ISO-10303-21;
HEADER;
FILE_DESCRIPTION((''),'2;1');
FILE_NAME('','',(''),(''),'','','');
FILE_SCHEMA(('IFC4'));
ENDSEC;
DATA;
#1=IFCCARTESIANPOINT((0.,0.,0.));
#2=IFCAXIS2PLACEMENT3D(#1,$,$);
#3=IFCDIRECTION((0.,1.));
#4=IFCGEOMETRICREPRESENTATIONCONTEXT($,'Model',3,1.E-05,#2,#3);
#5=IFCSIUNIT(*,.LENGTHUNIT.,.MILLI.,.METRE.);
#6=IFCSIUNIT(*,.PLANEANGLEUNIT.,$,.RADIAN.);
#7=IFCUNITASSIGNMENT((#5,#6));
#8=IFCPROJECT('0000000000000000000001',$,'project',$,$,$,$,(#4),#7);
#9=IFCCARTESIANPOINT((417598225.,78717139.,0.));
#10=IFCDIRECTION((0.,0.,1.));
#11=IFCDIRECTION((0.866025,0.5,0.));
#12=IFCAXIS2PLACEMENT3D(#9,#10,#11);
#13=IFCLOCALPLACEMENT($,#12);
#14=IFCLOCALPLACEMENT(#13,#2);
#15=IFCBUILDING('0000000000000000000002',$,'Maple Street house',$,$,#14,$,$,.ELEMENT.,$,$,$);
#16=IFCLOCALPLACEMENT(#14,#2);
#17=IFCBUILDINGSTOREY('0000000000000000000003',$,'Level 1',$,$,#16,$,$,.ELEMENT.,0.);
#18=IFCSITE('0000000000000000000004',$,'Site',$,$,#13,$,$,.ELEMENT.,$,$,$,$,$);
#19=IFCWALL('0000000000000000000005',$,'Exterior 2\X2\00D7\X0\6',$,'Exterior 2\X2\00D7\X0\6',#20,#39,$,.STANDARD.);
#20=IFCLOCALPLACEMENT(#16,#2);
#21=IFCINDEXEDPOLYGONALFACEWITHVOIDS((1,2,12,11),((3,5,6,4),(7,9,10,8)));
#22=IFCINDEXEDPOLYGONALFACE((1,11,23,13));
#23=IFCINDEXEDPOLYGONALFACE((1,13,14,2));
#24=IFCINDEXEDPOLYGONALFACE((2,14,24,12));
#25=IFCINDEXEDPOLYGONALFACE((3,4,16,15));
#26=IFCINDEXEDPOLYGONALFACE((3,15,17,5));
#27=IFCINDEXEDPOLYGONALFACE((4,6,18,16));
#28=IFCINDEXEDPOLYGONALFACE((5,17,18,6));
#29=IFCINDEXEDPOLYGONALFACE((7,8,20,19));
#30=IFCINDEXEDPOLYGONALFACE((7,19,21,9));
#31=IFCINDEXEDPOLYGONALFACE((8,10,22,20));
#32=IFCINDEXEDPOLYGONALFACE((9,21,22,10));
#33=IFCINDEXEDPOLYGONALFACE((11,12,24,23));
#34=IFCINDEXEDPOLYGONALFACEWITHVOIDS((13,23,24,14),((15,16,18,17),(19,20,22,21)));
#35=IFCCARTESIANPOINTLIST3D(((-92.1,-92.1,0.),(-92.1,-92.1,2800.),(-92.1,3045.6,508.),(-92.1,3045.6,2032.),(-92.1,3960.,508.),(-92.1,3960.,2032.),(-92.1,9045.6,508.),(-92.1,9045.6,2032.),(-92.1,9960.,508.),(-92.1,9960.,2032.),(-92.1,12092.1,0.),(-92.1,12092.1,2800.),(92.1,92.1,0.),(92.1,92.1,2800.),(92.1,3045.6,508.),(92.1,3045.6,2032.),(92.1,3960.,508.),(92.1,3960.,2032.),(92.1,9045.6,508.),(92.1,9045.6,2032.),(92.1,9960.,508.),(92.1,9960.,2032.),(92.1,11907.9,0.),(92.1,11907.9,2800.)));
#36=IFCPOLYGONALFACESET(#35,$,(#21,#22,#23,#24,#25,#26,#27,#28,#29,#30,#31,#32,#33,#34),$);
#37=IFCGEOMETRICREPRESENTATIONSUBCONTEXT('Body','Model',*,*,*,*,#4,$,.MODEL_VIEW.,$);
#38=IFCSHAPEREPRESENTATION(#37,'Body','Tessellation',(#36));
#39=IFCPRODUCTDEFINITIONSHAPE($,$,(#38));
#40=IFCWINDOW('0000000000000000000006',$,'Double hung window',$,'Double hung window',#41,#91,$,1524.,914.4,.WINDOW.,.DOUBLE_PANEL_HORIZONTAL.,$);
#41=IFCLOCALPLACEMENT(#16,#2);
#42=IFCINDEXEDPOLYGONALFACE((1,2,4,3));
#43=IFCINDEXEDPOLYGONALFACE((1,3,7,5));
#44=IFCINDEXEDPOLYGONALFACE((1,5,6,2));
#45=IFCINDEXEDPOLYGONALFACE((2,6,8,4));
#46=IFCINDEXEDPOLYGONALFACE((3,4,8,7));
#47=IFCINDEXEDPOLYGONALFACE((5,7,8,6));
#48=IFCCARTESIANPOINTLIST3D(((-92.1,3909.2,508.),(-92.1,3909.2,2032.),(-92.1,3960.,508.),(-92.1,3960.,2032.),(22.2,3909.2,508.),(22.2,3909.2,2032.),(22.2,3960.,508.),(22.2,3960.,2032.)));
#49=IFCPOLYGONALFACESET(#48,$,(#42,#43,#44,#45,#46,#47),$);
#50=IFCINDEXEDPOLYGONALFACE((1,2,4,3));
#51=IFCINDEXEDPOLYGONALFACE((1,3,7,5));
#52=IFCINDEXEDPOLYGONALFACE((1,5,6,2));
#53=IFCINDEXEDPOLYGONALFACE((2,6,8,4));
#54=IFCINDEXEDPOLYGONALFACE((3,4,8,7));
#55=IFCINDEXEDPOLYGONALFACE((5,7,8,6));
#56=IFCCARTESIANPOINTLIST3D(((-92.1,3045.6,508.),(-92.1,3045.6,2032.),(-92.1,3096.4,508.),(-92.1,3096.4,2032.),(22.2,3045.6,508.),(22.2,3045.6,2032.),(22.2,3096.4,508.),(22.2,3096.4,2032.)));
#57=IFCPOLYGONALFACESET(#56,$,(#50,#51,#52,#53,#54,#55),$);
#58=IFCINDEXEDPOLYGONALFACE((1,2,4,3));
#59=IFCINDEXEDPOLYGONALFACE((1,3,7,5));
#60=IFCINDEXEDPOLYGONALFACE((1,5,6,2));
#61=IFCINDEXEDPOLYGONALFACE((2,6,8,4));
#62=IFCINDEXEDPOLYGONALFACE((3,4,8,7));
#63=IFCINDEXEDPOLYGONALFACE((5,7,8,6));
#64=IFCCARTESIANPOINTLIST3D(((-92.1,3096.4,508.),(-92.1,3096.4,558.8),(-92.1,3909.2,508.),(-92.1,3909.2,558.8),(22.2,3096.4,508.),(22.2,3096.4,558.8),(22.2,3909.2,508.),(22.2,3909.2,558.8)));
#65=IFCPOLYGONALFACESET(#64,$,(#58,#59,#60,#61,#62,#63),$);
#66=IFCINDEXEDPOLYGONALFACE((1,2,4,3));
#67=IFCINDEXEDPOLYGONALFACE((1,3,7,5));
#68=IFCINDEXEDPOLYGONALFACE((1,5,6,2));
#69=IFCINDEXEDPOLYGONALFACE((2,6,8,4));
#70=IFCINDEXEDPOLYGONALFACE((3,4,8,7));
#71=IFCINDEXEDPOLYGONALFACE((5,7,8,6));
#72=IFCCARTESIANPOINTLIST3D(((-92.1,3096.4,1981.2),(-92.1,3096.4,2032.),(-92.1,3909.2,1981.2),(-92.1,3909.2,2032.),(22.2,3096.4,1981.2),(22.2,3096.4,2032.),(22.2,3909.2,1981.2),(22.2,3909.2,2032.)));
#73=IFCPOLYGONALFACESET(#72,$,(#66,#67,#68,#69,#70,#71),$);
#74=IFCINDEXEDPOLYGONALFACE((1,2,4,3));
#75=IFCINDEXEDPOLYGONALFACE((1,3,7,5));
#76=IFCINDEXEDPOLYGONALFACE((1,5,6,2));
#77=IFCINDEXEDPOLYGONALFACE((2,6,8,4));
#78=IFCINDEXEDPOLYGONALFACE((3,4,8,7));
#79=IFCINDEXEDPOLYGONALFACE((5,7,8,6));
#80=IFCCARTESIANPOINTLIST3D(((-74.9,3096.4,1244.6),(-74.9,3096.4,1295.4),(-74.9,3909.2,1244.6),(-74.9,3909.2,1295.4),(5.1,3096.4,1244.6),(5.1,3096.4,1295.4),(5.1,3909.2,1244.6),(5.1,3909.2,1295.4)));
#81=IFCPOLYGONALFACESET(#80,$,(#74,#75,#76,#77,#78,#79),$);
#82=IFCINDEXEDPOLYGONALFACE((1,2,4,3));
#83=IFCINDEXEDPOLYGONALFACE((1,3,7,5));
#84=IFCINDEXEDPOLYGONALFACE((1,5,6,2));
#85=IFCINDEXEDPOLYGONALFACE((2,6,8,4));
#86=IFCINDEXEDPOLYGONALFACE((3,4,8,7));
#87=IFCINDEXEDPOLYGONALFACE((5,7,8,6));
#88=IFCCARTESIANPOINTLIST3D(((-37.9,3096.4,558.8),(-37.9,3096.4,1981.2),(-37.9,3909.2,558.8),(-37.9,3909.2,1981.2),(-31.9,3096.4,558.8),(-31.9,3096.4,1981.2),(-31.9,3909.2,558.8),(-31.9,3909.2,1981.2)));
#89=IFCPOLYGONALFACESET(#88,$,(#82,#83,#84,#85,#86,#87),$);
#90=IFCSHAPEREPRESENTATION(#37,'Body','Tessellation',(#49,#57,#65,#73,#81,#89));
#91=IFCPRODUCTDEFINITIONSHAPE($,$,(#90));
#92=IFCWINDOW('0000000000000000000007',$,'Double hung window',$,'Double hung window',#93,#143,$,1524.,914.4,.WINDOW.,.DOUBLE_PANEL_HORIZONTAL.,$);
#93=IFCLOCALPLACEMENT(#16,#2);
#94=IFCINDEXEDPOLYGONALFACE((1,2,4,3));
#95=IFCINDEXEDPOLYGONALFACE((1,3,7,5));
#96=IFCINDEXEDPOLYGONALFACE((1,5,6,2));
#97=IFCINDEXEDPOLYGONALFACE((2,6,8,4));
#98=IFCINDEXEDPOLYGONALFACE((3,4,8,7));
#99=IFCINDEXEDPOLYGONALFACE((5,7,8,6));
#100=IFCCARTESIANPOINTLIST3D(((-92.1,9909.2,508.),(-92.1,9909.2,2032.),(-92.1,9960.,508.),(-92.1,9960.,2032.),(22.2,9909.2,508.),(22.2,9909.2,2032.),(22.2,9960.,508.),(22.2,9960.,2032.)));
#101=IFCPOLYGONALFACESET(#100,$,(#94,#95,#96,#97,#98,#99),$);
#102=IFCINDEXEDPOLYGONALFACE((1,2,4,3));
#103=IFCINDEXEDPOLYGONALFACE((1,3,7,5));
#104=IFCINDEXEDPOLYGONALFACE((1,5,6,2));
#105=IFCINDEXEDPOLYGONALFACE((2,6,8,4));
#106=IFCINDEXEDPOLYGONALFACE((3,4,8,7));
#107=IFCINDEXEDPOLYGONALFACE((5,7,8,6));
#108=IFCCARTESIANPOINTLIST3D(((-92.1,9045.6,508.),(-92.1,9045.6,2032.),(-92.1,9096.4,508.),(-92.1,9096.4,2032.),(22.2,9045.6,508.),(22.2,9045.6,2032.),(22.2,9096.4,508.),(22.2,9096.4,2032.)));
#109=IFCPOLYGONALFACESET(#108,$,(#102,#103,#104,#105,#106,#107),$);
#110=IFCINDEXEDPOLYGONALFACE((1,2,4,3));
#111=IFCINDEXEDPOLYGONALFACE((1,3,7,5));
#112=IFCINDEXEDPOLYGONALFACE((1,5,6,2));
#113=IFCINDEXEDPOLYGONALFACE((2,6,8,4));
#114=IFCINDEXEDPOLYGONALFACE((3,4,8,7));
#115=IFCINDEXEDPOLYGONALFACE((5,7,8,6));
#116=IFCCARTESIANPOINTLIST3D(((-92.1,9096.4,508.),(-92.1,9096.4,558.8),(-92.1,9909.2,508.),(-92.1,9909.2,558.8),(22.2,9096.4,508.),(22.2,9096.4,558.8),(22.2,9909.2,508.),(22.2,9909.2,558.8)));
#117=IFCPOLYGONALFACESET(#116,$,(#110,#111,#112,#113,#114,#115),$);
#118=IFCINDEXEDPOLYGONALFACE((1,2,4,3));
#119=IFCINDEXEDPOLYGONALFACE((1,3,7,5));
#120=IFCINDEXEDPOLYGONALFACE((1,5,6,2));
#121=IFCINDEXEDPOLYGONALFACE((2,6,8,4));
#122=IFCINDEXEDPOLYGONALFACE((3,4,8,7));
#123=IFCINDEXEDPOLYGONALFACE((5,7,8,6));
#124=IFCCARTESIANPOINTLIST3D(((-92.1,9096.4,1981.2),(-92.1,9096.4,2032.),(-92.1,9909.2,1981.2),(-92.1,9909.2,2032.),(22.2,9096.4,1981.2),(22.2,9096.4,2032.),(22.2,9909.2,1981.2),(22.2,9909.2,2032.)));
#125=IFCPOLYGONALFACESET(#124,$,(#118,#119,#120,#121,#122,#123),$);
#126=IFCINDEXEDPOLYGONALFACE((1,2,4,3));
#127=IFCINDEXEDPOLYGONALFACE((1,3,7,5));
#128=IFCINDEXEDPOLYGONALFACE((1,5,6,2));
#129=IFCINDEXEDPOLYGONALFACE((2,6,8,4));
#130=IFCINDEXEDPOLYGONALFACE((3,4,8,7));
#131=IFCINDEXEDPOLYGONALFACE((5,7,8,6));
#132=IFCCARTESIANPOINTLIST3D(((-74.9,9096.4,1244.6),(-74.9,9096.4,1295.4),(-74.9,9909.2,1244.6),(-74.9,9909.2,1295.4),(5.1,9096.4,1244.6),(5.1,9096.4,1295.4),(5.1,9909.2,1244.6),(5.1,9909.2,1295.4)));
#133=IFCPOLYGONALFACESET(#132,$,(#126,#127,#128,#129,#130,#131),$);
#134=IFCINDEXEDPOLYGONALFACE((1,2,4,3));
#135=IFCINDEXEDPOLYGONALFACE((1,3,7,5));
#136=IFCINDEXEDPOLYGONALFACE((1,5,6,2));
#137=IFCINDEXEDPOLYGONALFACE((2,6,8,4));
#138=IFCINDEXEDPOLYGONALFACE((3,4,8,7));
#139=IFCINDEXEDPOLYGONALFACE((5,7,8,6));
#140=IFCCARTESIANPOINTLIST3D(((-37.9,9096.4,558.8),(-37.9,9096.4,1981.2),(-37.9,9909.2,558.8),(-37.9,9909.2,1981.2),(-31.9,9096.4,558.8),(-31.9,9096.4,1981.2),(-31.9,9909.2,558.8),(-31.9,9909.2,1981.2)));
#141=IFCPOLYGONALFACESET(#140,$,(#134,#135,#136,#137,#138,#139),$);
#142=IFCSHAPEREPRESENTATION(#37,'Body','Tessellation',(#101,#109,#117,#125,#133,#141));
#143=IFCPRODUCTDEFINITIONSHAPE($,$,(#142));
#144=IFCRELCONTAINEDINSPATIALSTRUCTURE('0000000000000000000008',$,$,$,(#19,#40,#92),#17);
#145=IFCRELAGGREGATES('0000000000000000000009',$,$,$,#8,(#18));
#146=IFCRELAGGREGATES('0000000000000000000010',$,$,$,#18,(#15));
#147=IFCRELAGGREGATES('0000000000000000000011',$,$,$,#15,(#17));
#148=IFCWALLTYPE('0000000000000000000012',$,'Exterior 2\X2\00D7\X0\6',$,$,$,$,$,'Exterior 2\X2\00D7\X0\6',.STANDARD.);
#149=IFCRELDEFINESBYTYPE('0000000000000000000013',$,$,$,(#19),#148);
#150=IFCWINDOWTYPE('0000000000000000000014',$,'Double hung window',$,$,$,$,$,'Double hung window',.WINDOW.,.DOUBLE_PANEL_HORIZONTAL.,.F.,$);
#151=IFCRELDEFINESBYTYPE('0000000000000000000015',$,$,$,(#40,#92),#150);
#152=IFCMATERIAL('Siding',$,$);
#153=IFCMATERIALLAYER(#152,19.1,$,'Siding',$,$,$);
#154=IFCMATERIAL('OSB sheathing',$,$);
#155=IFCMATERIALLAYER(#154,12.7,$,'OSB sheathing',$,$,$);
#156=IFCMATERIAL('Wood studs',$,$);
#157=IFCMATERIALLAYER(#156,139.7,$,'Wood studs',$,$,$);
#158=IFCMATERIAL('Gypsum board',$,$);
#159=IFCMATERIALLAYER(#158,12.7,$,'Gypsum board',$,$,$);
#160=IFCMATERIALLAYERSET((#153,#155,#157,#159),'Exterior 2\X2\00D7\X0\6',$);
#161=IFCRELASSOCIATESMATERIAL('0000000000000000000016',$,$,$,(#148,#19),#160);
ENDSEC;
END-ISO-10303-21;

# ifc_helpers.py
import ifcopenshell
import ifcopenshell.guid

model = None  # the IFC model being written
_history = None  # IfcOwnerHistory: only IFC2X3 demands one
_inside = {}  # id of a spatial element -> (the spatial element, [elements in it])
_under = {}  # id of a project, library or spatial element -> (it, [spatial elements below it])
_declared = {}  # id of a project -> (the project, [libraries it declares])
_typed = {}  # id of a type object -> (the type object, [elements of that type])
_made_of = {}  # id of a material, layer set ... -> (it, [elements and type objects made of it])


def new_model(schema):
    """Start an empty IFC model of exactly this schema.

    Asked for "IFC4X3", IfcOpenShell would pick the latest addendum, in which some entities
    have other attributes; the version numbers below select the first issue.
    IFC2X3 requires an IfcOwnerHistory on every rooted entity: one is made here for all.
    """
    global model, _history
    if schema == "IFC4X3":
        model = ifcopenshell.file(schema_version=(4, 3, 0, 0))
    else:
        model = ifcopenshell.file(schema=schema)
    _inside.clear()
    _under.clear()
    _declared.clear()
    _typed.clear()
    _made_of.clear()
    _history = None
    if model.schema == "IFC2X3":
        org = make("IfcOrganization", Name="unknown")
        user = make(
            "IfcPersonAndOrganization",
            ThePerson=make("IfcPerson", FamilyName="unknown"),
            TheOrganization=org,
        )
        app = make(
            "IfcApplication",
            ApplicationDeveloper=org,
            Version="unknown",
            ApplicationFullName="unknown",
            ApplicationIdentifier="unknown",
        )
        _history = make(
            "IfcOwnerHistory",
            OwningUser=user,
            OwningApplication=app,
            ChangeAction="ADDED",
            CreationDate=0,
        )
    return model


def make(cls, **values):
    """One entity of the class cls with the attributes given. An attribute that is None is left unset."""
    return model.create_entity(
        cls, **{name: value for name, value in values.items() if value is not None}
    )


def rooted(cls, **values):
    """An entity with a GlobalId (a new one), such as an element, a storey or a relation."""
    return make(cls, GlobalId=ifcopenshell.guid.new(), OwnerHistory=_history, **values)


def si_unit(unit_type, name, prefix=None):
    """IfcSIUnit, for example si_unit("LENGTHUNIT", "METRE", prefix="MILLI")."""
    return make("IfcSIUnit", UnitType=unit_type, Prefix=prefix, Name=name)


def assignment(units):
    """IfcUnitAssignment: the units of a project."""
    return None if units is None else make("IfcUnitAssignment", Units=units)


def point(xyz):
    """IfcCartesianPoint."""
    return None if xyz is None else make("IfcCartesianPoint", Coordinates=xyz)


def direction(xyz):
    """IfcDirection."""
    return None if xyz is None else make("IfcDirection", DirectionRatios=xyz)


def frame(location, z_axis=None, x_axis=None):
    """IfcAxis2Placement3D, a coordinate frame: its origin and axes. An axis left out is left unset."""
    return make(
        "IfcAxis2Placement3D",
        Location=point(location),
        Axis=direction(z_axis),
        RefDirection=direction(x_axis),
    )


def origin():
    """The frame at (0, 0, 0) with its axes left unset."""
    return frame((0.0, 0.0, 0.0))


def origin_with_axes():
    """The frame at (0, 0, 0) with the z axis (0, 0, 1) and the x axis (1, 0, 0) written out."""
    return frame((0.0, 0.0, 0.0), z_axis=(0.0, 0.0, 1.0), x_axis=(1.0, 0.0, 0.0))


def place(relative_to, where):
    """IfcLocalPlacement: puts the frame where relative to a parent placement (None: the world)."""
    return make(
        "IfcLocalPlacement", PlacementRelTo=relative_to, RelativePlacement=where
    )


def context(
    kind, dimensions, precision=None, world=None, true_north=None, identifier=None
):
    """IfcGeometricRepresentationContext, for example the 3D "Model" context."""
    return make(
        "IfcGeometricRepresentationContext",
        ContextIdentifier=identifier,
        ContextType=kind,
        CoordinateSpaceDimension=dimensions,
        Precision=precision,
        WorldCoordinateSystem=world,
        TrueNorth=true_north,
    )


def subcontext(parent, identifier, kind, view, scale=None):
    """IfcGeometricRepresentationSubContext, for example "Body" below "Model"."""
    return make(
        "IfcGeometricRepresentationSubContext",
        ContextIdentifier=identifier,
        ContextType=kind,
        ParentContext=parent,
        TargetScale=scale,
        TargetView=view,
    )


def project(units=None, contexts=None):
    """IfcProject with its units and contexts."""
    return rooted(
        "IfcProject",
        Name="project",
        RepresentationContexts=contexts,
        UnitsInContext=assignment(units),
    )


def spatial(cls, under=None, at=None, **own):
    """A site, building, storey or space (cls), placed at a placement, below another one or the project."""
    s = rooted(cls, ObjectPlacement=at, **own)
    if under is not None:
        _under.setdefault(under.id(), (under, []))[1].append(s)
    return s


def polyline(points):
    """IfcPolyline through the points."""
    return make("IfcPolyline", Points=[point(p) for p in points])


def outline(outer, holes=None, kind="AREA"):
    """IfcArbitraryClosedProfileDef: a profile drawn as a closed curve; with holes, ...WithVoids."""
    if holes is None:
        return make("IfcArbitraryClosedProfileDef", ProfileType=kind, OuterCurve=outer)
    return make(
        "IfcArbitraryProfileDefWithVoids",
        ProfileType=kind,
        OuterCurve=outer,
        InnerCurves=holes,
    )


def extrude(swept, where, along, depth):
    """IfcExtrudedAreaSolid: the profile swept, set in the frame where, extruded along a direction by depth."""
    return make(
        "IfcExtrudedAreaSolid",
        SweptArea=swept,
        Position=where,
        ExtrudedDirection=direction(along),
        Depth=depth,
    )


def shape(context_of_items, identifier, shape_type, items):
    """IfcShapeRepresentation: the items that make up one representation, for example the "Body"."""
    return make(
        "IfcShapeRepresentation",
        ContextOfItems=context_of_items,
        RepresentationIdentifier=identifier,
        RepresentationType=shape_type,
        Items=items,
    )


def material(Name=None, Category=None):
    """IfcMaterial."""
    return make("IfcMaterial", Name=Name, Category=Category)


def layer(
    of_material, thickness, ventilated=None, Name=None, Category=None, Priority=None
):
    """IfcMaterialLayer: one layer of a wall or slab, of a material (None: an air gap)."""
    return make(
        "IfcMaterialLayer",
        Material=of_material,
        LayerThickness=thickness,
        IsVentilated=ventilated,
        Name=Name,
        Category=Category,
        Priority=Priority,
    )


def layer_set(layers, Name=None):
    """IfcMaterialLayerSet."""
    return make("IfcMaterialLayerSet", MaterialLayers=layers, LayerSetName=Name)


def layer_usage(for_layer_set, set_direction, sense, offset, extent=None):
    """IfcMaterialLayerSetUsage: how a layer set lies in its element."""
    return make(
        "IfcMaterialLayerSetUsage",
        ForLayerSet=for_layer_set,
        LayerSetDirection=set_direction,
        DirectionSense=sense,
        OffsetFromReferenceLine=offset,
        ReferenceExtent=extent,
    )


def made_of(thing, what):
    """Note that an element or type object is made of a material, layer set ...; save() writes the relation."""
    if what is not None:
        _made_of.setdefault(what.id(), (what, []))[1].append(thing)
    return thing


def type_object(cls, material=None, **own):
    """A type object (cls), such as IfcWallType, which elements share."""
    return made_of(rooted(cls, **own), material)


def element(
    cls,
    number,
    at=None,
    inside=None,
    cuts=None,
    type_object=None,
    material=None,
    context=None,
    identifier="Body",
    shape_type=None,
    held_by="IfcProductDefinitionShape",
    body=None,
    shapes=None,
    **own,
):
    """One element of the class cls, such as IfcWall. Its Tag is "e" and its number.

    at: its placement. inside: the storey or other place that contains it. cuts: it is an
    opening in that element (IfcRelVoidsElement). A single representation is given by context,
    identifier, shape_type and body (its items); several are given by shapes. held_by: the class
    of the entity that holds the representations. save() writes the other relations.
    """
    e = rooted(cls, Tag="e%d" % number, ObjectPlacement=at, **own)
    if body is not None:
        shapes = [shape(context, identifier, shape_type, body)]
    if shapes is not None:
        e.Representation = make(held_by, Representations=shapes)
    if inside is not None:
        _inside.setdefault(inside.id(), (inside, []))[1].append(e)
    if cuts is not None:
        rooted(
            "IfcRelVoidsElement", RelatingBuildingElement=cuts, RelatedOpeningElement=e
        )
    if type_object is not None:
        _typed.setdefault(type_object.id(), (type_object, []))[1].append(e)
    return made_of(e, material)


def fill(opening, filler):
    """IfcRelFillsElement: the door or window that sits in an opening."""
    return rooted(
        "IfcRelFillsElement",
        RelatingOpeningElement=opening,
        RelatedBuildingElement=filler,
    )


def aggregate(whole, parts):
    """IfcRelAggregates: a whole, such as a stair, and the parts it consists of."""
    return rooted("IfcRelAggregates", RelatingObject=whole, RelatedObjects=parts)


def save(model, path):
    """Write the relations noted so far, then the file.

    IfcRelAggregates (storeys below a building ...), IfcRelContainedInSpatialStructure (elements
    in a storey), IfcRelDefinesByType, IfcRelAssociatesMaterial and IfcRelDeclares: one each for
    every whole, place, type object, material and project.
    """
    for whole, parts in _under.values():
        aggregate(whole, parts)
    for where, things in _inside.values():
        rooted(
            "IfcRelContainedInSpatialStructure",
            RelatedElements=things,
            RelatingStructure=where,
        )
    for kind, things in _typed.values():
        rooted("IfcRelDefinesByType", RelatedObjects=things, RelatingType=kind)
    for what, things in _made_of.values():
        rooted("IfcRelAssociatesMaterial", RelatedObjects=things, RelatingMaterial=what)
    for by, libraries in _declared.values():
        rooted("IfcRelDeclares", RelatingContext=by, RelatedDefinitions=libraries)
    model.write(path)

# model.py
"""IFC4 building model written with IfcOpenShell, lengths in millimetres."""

from ifc_helpers import new_model, si_unit, direction, frame, origin, origin_with_axes, place, context, subcontext, project, spatial, polyline, outline, extrude, material, layer, layer_set, layer_usage, type_object, element, fill, save


model = new_model("IFC4")

# Units and contexts
model_context = context("Model", 3, precision=1e-05, world=origin(), true_north=direction((0.0, 1.0)))
body_context = subcontext(model_context, "Body", "Model", "MODEL_VIEW")
ifc_project = project(units=[si_unit("LENGTHUNIT", "METRE", prefix="MILLI"), si_unit("PLANEANGLEUNIT", "RADIAN")], contexts=[model_context])

# Site, building, storey
site_placement = place(None, frame((417598225.0, 78717139.0, 0.0), z_axis=(0.0, 0.0, 1.0), x_axis=(0.866025, 0.5, 0.0)))
site = spatial("IfcSite", under=ifc_project, at=site_placement, Name="Site", CompositionType="ELEMENT")
building_placement = place(site_placement, origin())
building = spatial("IfcBuilding", under=site, at=building_placement, Name="Maple Street house", CompositionType="ELEMENT")
storey_placement = place(building_placement, origin())
storey = spatial("IfcBuildingStorey", under=building, at=storey_placement, Name="Level 1", CompositionType="ELEMENT", Elevation=0.0)

# Shared definitions
ifc_material_1 = material(Name="Siding")
ifc_layer_1 = layer(ifc_material_1, 19.1, Name="Siding")
ifc_material_2 = material(Name="OSB sheathing")
ifc_layer_2 = layer(ifc_material_2, 12.7, Name="OSB sheathing")
ifc_material_3 = material(Name="Wood studs")
ifc_layer_3 = layer(ifc_material_3, 139.7, Name="Wood studs")
ifc_material_4 = material(Name="Gypsum board")
ifc_layer_4 = layer(ifc_material_4, 12.7, Name="Gypsum board")
ifc_layer_set_1 = layer_set([ifc_layer_1, ifc_layer_2, ifc_layer_3, ifc_layer_4], Name="Exterior 2×6")
wall_type_1 = type_object("IfcWallType", Name="Exterior 2×6", ElementType="Exterior 2×6", PredefinedType="STANDARD", material=ifc_layer_set_1)

# Shared definitions
window_type_1 = type_object("IfcWindowType", Name="Double hung window", ElementType="Double hung window", ParameterTakesPrecedence=False, PartitioningType="DOUBLE_PANEL_HORIZONTAL", PredefinedType="WINDOW")

# Wall, openings, windows
ifc_layer_usage_1 = layer_usage(ifc_layer_set_1, "AXIS2", "POSITIVE", -92.1)
wall_1_placement = place(storey_placement, frame((0.0, 12000.0, 0.0), z_axis=(0.0, 0.0, 1.0), x_axis=(0.0, -1.0, 0.0)))
wall_1 = element("IfcWall", 1, at=wall_1_placement, inside=storey, type_object=wall_type_1, material=ifc_layer_usage_1, Name="Exterior 2×6", ObjectType="Exterior 2×6", PredefinedType="STANDARD", context=body_context, shape_type="SweptSolid", body=[
    extrude(outline(polyline([(-92.1, -92.1), (12092.1, -92.1), (11907.9, 92.1), (92.1, 92.1), (-92.1, -92.1)])), origin(), (0.0, 0.0, 1.0), 2800.0),
])
opening_1_placement = place(wall_1_placement, frame((8040.0, 0.0, 508.0), z_axis=(0.0, 0.0, 1.0), x_axis=(1.0, 0.0, 0.0)))
opening_1 = element("IfcOpeningElement", 2, at=opening_1_placement, cuts=wall_1, PredefinedType="OPENING", context=body_context, shape_type="SweptSolid", body=[
    extrude(outline(polyline([(0.0, -102.1), (914.4, -102.1), (914.4, 102.1), (0.0, 102.1), (0.0, -102.1)])), origin(), (0.0, 0.0, 1.0), 1524.0),
])
opening_2_placement = place(wall_1_placement, frame((2040.0, 0.0, 508.0), z_axis=(0.0, 0.0, 1.0), x_axis=(1.0, 0.0, 0.0)))
opening_2 = element("IfcOpeningElement", 3, at=opening_2_placement, cuts=wall_1, PredefinedType="OPENING", context=body_context, shape_type="SweptSolid", body=[
    extrude(outline(polyline([(0.0, -102.1), (914.4, -102.1), (914.4, 102.1), (0.0, 102.1), (0.0, -102.1)])), origin(), (0.0, 0.0, 1.0), 1524.0),
])
window_1_placement = place(opening_1_placement, origin_with_axes())
window_1 = element("IfcWindow", 4, at=window_1_placement, inside=storey, type_object=window_type_1, Name="Double hung window", ObjectType="Double hung window", OverallHeight=1524.0, OverallWidth=914.4, PartitioningType="DOUBLE_PANEL_HORIZONTAL", PredefinedType="WINDOW", context=body_context, shape_type="SweptSolid", body=[
    extrude(outline(polyline([(0.0, -92.1), (50.8, -92.1), (50.8, 22.2), (0.0, 22.2), (0.0, -92.1)])), origin(), (0.0, 0.0, 1.0), 1524.0),
    extrude(outline(polyline([(863.6, -92.1), (914.4, -92.1), (914.4, 22.2), (863.6, 22.2), (863.6, -92.1)])), origin(), (0.0, 0.0, 1.0), 1524.0),
    extrude(outline(polyline([(50.8, -92.1), (863.6, -92.1), (863.6, 22.2), (50.8, 22.2), (50.8, -92.1)])), origin(), (0.0, 0.0, 1.0), 50.8),
    extrude(outline(polyline([(50.8, -92.1), (863.6, -92.1), (863.6, 22.2), (50.8, 22.2), (50.8, -92.1)])), frame((0.0, 0.0, 1473.2)), (0.0, 0.0, 1.0), 50.8),
    extrude(outline(polyline([(50.8, -74.9), (863.6, -74.9), (863.6, 5.1), (50.8, 5.1), (50.8, -74.9)])), frame((0.0, 0.0, 736.6)), (0.0, 0.0, 1.0), 50.8),
    extrude(outline(polyline([(50.8, -37.9), (863.6, -37.9), (863.6, -31.9), (50.8, -31.9), (50.8, -37.9)])), frame((0.0, 0.0, 50.8)), (0.0, 0.0, 1.0), 1422.4),
])
fill(opening_1, window_1)
window_2_placement = place(opening_2_placement, origin_with_axes())
window_2 = element("IfcWindow", 5, at=window_2_placement, inside=storey, type_object=window_type_1, Name="Double hung window", ObjectType="Double hung window", OverallHeight=1524.0, OverallWidth=914.4, PartitioningType="DOUBLE_PANEL_HORIZONTAL", PredefinedType="WINDOW", context=body_context, shape_type="SweptSolid", body=[
    extrude(outline(polyline([(0.0, -92.1), (50.8, -92.1), (50.8, 22.2), (0.0, 22.2), (0.0, -92.1)])), origin(), (0.0, 0.0, 1.0), 1524.0),
    extrude(outline(polyline([(863.6, -92.1), (914.4, -92.1), (914.4, 22.2), (863.6, 22.2), (863.6, -92.1)])), origin(), (0.0, 0.0, 1.0), 1524.0),
    extrude(outline(polyline([(50.8, -92.1), (863.6, -92.1), (863.6, 22.2), (50.8, 22.2), (50.8, -92.1)])), origin(), (0.0, 0.0, 1.0), 50.8),
    extrude(outline(polyline([(50.8, -92.1), (863.6, -92.1), (863.6, 22.2), (50.8, 22.2), (50.8, -92.1)])), frame((0.0, 0.0, 1473.2)), (0.0, 0.0, 1.0), 50.8),
    extrude(outline(polyline([(50.8, -74.9), (863.6, -74.9), (863.6, 5.1), (50.8, 5.1), (50.8, -74.9)])), frame((0.0, 0.0, 736.6)), (0.0, 0.0, 1.0), 50.8),
    extrude(outline(polyline([(50.8, -37.9), (863.6, -37.9), (863.6, -31.9), (50.8, -31.9), (50.8, -37.9)])), frame((0.0, 0.0, 50.8)), (0.0, 0.0, 1.0), 1422.4),
])
fill(opening_2, window_2)

save(model, "model.ifc")
